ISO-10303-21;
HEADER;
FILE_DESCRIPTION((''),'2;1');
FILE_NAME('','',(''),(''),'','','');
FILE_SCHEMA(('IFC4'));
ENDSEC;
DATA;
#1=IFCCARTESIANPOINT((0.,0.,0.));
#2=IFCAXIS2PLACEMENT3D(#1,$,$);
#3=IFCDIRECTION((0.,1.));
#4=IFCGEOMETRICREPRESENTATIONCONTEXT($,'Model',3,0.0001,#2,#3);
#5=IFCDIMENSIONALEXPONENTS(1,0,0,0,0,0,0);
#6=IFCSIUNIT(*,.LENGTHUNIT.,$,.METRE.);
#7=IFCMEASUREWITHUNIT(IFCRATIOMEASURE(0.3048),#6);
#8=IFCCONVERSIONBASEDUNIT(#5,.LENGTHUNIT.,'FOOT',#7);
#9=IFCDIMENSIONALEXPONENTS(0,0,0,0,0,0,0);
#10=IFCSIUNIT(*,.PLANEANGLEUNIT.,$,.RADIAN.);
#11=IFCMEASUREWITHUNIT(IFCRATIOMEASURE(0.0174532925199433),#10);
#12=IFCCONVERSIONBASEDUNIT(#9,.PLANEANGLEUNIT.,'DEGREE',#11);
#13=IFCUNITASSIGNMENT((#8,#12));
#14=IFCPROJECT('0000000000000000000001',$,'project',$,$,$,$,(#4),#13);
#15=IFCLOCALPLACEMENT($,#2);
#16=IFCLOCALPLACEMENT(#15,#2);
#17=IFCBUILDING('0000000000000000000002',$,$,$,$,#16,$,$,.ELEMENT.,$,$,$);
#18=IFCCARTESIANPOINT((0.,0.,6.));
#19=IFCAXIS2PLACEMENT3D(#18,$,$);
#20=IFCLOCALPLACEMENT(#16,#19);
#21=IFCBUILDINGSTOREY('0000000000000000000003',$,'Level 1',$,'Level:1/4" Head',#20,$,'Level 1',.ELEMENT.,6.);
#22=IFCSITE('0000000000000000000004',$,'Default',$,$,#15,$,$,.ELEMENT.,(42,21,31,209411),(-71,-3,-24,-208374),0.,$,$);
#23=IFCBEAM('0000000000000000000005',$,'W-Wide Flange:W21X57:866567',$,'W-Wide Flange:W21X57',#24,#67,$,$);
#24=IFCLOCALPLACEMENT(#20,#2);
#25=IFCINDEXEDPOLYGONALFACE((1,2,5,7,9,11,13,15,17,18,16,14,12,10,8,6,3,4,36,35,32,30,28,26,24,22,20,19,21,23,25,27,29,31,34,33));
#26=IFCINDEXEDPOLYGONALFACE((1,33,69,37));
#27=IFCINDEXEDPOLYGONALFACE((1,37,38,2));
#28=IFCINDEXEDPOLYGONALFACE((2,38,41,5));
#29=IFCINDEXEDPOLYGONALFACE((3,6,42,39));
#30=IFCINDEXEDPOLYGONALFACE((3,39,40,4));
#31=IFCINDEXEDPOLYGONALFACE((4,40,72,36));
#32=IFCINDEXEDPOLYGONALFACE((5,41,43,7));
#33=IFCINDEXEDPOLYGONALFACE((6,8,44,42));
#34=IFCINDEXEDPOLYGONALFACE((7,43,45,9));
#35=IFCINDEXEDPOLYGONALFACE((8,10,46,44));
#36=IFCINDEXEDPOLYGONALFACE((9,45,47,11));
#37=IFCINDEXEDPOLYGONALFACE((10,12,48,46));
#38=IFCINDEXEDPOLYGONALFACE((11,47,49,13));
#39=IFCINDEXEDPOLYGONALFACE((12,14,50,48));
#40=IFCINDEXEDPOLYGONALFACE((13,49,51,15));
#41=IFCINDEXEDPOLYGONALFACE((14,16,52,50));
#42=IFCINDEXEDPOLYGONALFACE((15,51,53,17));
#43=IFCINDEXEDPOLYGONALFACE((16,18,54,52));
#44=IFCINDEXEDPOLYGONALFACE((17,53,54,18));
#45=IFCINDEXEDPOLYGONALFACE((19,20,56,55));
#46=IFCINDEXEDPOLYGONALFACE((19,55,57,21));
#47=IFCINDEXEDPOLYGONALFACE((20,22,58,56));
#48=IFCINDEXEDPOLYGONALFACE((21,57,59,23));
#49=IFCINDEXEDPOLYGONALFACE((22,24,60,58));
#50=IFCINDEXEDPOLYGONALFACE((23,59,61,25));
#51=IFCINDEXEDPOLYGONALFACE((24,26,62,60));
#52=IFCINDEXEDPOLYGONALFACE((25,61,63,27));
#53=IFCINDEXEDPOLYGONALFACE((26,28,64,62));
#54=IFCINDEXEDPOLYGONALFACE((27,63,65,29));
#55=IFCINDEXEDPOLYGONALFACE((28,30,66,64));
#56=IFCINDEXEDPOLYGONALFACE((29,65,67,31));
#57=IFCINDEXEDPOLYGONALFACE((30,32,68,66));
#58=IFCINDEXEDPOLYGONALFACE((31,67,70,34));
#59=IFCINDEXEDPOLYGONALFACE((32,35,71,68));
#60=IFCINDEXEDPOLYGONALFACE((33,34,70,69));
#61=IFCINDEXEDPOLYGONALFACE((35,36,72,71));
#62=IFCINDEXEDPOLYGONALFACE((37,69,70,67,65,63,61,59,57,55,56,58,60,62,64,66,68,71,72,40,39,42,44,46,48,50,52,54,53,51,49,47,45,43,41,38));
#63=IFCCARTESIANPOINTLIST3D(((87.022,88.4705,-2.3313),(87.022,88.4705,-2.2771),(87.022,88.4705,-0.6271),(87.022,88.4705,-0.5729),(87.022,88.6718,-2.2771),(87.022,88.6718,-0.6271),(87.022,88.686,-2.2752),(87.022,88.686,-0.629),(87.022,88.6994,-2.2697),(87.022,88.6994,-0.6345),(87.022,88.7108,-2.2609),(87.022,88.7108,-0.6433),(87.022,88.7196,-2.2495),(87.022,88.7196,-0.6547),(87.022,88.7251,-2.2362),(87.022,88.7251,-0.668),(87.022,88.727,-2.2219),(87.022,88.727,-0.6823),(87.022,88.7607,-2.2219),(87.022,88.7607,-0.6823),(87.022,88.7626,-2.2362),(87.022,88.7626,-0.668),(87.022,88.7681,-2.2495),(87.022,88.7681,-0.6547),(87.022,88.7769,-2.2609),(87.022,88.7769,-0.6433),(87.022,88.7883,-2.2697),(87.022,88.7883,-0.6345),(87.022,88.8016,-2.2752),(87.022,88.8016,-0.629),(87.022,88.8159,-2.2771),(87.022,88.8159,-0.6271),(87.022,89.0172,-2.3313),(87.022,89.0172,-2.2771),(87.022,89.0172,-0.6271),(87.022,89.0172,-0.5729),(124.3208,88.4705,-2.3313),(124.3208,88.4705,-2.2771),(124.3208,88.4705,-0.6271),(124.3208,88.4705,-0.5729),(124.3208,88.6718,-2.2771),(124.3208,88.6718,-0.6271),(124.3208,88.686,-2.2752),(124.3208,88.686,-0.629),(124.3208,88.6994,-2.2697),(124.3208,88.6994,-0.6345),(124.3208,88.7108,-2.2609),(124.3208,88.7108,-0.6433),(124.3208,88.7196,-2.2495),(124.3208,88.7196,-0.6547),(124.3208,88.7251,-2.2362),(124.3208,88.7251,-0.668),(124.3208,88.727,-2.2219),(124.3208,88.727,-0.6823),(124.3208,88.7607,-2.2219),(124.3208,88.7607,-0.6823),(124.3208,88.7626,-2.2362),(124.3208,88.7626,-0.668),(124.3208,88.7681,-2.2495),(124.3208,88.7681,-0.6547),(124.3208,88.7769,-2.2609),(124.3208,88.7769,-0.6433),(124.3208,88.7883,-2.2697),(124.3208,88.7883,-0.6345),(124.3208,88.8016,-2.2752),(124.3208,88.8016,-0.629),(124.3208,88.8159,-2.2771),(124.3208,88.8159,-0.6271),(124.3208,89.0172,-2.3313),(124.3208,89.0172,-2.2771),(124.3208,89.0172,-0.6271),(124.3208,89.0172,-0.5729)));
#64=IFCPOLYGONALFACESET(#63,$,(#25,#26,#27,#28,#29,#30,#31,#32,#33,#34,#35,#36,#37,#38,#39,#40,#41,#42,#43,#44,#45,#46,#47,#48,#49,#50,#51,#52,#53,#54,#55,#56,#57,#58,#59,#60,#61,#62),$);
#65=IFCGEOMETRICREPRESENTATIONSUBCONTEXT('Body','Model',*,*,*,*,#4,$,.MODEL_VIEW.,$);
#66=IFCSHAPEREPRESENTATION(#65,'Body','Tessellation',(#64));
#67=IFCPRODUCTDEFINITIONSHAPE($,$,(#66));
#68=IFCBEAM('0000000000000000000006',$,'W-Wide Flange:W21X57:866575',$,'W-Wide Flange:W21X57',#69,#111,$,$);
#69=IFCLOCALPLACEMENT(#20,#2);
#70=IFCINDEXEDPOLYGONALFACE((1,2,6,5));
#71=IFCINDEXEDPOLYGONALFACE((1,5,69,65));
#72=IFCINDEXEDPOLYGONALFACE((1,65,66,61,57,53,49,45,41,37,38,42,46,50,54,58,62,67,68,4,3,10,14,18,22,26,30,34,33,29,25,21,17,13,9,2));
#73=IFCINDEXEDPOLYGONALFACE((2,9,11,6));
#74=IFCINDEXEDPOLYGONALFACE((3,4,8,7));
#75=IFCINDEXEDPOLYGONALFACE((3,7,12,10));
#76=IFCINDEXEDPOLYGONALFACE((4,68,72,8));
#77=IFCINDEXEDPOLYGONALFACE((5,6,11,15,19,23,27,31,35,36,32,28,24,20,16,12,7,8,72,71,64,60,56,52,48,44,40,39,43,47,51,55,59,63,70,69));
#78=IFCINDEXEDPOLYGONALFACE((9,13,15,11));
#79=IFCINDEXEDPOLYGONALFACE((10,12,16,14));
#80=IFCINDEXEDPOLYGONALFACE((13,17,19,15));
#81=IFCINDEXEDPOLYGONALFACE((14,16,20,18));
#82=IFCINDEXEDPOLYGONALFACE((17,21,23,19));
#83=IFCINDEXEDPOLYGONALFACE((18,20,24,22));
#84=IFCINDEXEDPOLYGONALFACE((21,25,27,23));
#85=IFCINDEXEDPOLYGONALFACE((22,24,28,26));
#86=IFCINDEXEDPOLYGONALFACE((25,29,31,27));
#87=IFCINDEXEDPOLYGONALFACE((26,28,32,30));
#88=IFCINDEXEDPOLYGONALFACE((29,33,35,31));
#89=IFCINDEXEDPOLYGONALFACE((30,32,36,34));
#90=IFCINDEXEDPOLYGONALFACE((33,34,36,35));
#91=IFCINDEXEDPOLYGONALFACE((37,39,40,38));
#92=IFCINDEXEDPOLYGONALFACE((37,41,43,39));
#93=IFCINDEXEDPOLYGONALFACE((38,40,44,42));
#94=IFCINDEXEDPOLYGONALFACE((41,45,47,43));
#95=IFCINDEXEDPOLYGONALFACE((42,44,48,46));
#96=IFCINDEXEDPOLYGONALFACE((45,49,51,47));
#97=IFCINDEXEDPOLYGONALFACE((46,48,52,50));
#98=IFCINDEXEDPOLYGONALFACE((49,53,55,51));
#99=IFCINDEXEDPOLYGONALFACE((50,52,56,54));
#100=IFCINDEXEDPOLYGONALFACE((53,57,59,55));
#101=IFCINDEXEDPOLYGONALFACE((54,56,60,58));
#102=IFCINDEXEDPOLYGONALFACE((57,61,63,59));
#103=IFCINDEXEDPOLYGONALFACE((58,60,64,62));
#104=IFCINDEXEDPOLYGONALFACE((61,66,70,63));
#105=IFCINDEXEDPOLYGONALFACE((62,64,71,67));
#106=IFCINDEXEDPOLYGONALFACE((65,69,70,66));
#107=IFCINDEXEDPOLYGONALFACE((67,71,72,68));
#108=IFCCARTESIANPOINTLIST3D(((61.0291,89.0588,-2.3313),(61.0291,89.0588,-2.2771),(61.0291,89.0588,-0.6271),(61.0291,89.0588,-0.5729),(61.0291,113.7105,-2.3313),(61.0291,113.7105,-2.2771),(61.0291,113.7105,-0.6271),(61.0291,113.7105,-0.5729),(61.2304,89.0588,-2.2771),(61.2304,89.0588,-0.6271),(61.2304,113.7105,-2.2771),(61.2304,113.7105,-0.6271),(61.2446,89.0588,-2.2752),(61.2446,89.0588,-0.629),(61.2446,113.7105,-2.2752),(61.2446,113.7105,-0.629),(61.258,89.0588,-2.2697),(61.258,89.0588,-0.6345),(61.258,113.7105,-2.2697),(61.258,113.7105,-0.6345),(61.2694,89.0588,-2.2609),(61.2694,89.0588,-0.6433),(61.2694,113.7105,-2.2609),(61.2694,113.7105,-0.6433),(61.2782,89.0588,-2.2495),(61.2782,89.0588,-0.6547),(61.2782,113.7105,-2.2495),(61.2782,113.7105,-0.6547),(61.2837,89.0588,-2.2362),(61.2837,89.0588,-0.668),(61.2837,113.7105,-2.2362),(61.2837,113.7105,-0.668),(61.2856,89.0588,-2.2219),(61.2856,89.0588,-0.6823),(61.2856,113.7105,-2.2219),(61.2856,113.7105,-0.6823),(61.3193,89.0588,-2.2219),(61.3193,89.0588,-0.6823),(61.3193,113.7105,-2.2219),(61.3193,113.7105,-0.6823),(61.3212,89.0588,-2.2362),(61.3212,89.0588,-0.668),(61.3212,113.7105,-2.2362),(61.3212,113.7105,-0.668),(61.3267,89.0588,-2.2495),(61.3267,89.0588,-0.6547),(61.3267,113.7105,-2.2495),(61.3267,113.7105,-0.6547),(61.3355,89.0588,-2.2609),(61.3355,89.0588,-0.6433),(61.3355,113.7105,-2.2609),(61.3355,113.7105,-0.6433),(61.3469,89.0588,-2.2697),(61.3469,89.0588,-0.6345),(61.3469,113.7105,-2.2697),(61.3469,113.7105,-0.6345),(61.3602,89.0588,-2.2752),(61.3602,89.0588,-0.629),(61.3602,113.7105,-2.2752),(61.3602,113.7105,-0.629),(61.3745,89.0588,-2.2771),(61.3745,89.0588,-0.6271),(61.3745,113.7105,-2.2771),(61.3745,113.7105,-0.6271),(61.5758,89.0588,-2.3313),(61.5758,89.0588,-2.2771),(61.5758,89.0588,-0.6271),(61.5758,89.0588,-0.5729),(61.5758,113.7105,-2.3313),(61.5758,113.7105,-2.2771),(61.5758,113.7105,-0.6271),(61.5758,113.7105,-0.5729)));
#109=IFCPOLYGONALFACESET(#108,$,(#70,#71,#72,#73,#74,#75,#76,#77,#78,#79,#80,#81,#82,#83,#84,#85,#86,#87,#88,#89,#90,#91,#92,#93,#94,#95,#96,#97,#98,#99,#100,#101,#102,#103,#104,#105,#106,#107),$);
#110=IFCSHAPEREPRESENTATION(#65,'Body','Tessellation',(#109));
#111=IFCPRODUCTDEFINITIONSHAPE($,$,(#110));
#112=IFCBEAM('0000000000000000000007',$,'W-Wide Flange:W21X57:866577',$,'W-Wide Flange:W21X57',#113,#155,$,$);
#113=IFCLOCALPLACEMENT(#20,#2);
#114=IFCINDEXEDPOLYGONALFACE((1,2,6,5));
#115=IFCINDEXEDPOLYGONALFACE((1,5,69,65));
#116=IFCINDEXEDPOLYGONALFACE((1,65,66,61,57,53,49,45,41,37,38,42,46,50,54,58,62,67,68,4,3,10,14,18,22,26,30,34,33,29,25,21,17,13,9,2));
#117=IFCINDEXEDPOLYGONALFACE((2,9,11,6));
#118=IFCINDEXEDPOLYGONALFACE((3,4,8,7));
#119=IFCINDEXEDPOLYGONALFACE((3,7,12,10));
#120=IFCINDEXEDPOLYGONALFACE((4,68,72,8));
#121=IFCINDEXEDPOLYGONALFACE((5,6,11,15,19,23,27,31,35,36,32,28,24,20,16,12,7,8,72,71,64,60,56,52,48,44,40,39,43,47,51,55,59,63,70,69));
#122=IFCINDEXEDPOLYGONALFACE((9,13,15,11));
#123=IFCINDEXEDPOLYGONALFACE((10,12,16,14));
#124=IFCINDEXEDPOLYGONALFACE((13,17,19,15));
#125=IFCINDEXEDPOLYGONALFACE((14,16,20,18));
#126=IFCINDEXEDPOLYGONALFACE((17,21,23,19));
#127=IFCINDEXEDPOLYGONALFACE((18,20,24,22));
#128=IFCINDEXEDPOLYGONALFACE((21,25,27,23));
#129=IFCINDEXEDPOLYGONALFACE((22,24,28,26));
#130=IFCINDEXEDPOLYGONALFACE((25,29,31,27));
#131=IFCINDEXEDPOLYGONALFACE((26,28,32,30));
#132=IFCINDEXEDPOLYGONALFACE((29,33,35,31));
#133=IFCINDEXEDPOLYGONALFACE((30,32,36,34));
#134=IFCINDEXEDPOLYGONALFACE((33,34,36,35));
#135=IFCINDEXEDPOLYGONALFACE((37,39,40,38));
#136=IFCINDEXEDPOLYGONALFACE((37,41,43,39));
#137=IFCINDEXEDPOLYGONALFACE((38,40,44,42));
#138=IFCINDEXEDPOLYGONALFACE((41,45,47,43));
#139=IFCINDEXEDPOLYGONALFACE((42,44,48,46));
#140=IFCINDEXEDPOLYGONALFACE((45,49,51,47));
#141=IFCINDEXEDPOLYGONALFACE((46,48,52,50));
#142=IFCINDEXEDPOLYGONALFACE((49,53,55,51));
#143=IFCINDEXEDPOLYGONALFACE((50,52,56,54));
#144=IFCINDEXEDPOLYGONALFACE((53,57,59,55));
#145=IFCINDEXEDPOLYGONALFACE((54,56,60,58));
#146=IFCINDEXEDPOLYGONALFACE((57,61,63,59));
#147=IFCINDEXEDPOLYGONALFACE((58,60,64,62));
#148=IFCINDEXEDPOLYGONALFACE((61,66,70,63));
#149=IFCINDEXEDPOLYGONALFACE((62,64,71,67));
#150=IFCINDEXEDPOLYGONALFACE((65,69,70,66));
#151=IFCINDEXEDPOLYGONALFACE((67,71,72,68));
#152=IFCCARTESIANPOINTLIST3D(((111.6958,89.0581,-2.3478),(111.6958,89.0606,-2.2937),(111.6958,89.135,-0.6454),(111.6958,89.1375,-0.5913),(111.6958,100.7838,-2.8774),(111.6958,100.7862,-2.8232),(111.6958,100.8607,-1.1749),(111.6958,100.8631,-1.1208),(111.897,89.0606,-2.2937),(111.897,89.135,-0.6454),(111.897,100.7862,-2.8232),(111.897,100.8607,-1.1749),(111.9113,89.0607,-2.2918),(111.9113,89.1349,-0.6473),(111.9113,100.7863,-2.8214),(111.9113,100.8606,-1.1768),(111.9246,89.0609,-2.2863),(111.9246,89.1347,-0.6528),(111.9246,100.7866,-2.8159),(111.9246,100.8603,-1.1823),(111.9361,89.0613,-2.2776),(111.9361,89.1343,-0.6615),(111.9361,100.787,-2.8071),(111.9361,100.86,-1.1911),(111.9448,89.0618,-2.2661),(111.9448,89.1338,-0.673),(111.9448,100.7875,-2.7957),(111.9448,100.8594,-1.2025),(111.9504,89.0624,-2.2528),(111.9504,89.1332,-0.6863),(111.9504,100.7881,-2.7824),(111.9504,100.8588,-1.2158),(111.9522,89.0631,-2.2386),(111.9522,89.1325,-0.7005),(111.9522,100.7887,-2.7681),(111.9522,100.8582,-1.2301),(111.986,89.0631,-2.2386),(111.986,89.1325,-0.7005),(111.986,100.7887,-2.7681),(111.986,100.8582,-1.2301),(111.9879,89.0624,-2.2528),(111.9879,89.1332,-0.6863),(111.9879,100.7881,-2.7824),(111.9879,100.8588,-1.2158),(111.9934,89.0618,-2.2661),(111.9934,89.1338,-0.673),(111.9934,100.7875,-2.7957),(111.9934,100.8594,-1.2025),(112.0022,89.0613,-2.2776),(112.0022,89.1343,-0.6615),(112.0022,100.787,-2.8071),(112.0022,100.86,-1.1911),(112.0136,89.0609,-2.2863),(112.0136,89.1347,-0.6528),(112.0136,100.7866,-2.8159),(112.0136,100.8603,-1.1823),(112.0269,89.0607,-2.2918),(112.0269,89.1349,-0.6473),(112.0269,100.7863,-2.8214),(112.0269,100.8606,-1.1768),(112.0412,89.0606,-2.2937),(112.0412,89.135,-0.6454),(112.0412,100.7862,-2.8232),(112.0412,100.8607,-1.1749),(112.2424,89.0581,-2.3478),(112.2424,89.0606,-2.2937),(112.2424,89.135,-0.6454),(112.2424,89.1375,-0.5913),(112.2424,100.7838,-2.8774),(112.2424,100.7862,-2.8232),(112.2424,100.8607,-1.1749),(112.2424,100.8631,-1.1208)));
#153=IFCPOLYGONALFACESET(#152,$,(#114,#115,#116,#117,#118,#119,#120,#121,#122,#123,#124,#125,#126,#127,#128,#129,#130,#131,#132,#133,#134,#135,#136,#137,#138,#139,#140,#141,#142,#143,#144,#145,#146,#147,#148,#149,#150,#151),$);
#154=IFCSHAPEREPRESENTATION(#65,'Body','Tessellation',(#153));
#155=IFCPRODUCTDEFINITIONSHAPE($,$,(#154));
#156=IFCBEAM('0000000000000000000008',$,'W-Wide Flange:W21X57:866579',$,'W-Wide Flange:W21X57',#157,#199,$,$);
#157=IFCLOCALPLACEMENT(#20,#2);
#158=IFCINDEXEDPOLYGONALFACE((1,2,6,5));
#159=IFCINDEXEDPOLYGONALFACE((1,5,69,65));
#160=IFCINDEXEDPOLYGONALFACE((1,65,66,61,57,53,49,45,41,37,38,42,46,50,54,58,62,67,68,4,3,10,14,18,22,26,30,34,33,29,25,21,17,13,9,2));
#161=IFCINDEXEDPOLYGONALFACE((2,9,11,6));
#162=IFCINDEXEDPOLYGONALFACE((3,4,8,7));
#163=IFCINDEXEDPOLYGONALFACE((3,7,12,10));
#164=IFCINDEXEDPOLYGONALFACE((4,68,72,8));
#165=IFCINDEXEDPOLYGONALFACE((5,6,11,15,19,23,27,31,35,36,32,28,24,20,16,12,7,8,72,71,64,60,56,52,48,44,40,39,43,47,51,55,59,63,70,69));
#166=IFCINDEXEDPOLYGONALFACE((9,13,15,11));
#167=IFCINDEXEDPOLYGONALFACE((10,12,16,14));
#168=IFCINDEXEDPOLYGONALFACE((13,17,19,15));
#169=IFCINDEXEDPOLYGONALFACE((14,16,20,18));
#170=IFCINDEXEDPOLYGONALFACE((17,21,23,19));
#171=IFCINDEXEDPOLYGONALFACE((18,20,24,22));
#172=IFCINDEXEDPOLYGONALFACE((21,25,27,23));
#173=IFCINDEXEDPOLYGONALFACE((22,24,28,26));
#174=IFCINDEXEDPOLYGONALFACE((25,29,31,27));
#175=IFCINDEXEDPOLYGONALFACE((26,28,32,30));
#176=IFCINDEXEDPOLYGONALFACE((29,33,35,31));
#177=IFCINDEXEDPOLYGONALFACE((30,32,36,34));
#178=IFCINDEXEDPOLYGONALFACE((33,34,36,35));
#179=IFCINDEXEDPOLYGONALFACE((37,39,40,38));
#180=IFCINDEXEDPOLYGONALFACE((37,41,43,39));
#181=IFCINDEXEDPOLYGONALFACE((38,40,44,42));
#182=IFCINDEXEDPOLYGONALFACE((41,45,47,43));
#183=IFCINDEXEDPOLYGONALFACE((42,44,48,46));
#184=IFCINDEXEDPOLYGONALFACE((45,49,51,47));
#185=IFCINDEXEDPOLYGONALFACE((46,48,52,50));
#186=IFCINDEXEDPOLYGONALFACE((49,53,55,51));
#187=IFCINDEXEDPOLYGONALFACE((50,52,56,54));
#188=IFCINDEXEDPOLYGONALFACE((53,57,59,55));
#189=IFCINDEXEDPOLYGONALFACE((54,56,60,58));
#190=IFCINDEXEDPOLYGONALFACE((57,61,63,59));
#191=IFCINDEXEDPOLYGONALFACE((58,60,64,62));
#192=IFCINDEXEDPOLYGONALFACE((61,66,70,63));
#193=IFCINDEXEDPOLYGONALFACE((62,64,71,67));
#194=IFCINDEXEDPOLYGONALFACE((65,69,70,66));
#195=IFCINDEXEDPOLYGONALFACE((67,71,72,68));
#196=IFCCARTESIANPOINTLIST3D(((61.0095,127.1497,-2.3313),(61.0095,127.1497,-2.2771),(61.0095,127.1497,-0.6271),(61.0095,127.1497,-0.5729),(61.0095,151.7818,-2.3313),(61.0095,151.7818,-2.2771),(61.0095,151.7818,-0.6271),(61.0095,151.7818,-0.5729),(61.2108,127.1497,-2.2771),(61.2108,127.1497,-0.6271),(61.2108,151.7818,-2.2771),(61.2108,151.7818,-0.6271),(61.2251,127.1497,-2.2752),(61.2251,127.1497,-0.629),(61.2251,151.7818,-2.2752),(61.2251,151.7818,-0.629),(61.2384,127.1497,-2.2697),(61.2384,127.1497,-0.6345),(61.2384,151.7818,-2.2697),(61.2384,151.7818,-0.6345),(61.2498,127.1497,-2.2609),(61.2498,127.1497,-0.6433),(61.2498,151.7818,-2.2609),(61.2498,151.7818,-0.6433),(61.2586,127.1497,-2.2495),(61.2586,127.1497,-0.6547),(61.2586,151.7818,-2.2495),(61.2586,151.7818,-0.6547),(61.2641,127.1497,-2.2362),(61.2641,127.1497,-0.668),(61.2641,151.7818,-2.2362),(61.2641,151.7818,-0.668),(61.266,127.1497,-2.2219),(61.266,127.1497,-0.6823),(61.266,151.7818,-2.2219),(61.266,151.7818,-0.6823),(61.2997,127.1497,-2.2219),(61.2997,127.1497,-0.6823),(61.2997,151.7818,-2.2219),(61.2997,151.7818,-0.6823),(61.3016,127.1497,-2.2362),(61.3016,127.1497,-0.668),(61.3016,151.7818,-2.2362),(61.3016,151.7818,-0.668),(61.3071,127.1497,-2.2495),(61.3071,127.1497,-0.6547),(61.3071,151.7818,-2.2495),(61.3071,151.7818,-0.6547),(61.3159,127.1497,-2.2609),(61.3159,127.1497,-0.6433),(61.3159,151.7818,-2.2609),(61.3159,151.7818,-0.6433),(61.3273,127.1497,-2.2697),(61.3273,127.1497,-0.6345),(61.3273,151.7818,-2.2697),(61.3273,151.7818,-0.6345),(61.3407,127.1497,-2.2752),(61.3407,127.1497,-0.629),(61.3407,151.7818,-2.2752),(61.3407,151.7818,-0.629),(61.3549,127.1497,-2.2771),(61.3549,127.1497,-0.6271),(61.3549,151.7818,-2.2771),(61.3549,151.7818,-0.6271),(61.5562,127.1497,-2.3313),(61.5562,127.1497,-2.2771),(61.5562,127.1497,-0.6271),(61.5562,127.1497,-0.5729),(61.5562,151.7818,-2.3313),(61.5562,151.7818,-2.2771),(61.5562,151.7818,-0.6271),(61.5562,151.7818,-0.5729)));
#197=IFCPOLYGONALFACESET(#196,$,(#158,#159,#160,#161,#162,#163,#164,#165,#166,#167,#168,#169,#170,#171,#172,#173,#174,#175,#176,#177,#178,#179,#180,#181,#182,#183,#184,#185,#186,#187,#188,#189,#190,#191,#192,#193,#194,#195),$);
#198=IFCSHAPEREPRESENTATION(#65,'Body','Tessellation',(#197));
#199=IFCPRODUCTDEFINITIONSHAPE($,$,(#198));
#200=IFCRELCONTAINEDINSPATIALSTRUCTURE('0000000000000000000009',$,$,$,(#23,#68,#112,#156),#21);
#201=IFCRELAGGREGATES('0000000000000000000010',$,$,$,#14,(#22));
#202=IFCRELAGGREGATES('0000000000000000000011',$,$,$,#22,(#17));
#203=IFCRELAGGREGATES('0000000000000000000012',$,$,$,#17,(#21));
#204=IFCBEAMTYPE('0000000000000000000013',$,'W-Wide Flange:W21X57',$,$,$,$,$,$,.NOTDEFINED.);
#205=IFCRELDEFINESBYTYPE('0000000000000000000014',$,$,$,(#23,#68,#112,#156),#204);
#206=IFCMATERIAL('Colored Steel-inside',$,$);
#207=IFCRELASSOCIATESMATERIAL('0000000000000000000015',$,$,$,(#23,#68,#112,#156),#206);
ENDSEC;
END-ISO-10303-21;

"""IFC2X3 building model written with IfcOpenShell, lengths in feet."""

from ifc_helpers import new_model, entity, si_unit, converted_unit, direction, frame, frame_2d, origin, place, context, subcontext, project, spatial, i_section, extrude, material, type_object, element, save


model = new_model("IFC2X3")

# Units and contexts
model_context = context("Model", 3, precision=0.0001, world=origin(), true_north=direction((0.0, 1.0)))
body_context = subcontext(model_context, "Body", "Model", "MODEL_VIEW")
ifc_project = project(units=[converted_unit("LENGTHUNIT", "FOOT", entity("IfcRatioMeasure", 0.3048), si_unit("LENGTHUNIT", "METRE"), dimensions=[1, 0, 0, 0, 0, 0, 0]), converted_unit("PLANEANGLEUNIT", "DEGREE", entity("IfcRatioMeasure", 0.0174532925199433), si_unit("PLANEANGLEUNIT", "RADIAN"), dimensions=[0, 0, 0, 0, 0, 0, 0])], contexts=[model_context])

# Site, building, storey
site_placement = place(None, origin())
site = spatial("IfcSite", under=ifc_project, at=site_placement, Name="Default", CompositionType="ELEMENT", RefLatitude=(42, 21, 31, 209411), RefLongitude=(-71, -3, -24, -208374), RefElevation=0.0)
building_placement = place(site_placement, origin())
building = spatial("IfcBuilding", under=site, at=building_placement, CompositionType="ELEMENT")
storey_placement = place(building_placement, frame((0.0, 0.0, 6.0)))
storey = spatial("IfcBuildingStorey", under=building, at=storey_placement, Name="Level 1", ObjectType="Level:1/4\" Head", LongName="Level 1", CompositionType="ELEMENT", Elevation=6.0)

# Shared definitions
ifc_material_1 = material(Name="Colored Steel-inside")

# Beams
beam_type_1 = type_object("IfcBeamType", Name="W-Wide Flange:W21X57", PredefinedType="NOTDEFINED")
beam_1_placement = place(storey_placement, frame((124.6358, 88.7438, 0.0), z_axis=(0.0, 0.0, 1.0), x_axis=(-1.0, 0.0, 0.0)))
element("IfcBeam", 1, at=beam_1_placement, inside=storey, type_object=beam_type_1, material=ifc_material_1, Name="W-Wide Flange:W21X57:866567", ObjectType="W-Wide Flange:W21X57", context=body_context, shape_type="SweptSolid", body=[
    extrude(i_section(OverallWidth=0.5467, OverallDepth=1.7583, WebThickness=0.0337, FlangeThickness=0.0542, FilletRadius=0.0552, at=frame_2d((0.0, 0.0), x_axis=(0.0, 1.0))), frame((0.315, 0.0, -1.4521), z_axis=(1.0, 0.0, 0.0), x_axis=(0.0, 0.0, -1.0)), (0.0, 0.0, 1.0), 37.2988),
])
beam_2_placement = place(storey_placement, frame((61.3024, 114.0968, 0.0), z_axis=(0.0, 0.0, 1.0), x_axis=(0.0, -1.0, 0.0)))
element("IfcBeam", 2, at=beam_2_placement, inside=storey, type_object=beam_type_1, material=ifc_material_1, Name="W-Wide Flange:W21X57:866575", ObjectType="W-Wide Flange:W21X57", context=body_context, shape_type="SweptSolid", body=[
    extrude(i_section(OverallWidth=0.5467, OverallDepth=1.7583, WebThickness=0.0338, FlangeThickness=0.0542, FilletRadius=0.0552, at=frame_2d((0.0, 0.0), x_axis=(0.0, 1.0))), frame((0.3863, 0.0, -1.4521), z_axis=(1.0, 0.0, 0.0), x_axis=(0.0, 0.0, -1.0)), (0.0, 0.0, 1.0), 24.6517),
])
beam_3_placement = place(storey_placement, frame((111.9691, 88.7438, 0.0), z_axis=(0.0, 0.045114, 0.998982), x_axis=(0.0, 0.998982, -0.045114)))
element("IfcBeam", 3, at=beam_3_placement, inside=storey, type_object=beam_type_1, material=ifc_material_1, Name="W-Wide Flange:W21X57:866577", ObjectType="W-Wide Flange:W21X57", context=body_context, shape_type="SweptSolid", body=[
    extrude(i_section(OverallWidth=0.5467, OverallDepth=1.7583, WebThickness=0.0337, FlangeThickness=0.0542, FilletRadius=0.0552, at=frame_2d((0.0, 0.0), x_axis=(0.0, 1.0))), frame((0.4199, 0.0, -1.4521), z_axis=(1.0, 0.0, 0.0), x_axis=(0.0, 0.0, -1.0)), (0.0, 0.0, 1.0), 11.7376),
])
beam_4_placement = place(storey_placement, frame((61.2829, 152.0928, 0.0), z_axis=(0.0, 0.0, 1.0), x_axis=(0.0, -1.0, 0.0)))
element("IfcBeam", 4, at=beam_4_placement, inside=storey, type_object=beam_type_1, material=ifc_material_1, Name="W-Wide Flange:W21X57:866579", ObjectType="W-Wide Flange:W21X57", context=body_context, shape_type="SweptSolid", body=[
    extrude(i_section(OverallWidth=0.5467, OverallDepth=1.7583, WebThickness=0.0338, FlangeThickness=0.0542, FilletRadius=0.0552, at=frame_2d((0.0, 0.0), x_axis=(0.0, 1.0))), frame((0.311, 0.0, -1.4521), z_axis=(1.0, 0.0, 0.0), x_axis=(0.0, 0.0, -1.0)), (0.0, 0.0, 1.0), 24.6321),
])

save(model, "model.ifc")
